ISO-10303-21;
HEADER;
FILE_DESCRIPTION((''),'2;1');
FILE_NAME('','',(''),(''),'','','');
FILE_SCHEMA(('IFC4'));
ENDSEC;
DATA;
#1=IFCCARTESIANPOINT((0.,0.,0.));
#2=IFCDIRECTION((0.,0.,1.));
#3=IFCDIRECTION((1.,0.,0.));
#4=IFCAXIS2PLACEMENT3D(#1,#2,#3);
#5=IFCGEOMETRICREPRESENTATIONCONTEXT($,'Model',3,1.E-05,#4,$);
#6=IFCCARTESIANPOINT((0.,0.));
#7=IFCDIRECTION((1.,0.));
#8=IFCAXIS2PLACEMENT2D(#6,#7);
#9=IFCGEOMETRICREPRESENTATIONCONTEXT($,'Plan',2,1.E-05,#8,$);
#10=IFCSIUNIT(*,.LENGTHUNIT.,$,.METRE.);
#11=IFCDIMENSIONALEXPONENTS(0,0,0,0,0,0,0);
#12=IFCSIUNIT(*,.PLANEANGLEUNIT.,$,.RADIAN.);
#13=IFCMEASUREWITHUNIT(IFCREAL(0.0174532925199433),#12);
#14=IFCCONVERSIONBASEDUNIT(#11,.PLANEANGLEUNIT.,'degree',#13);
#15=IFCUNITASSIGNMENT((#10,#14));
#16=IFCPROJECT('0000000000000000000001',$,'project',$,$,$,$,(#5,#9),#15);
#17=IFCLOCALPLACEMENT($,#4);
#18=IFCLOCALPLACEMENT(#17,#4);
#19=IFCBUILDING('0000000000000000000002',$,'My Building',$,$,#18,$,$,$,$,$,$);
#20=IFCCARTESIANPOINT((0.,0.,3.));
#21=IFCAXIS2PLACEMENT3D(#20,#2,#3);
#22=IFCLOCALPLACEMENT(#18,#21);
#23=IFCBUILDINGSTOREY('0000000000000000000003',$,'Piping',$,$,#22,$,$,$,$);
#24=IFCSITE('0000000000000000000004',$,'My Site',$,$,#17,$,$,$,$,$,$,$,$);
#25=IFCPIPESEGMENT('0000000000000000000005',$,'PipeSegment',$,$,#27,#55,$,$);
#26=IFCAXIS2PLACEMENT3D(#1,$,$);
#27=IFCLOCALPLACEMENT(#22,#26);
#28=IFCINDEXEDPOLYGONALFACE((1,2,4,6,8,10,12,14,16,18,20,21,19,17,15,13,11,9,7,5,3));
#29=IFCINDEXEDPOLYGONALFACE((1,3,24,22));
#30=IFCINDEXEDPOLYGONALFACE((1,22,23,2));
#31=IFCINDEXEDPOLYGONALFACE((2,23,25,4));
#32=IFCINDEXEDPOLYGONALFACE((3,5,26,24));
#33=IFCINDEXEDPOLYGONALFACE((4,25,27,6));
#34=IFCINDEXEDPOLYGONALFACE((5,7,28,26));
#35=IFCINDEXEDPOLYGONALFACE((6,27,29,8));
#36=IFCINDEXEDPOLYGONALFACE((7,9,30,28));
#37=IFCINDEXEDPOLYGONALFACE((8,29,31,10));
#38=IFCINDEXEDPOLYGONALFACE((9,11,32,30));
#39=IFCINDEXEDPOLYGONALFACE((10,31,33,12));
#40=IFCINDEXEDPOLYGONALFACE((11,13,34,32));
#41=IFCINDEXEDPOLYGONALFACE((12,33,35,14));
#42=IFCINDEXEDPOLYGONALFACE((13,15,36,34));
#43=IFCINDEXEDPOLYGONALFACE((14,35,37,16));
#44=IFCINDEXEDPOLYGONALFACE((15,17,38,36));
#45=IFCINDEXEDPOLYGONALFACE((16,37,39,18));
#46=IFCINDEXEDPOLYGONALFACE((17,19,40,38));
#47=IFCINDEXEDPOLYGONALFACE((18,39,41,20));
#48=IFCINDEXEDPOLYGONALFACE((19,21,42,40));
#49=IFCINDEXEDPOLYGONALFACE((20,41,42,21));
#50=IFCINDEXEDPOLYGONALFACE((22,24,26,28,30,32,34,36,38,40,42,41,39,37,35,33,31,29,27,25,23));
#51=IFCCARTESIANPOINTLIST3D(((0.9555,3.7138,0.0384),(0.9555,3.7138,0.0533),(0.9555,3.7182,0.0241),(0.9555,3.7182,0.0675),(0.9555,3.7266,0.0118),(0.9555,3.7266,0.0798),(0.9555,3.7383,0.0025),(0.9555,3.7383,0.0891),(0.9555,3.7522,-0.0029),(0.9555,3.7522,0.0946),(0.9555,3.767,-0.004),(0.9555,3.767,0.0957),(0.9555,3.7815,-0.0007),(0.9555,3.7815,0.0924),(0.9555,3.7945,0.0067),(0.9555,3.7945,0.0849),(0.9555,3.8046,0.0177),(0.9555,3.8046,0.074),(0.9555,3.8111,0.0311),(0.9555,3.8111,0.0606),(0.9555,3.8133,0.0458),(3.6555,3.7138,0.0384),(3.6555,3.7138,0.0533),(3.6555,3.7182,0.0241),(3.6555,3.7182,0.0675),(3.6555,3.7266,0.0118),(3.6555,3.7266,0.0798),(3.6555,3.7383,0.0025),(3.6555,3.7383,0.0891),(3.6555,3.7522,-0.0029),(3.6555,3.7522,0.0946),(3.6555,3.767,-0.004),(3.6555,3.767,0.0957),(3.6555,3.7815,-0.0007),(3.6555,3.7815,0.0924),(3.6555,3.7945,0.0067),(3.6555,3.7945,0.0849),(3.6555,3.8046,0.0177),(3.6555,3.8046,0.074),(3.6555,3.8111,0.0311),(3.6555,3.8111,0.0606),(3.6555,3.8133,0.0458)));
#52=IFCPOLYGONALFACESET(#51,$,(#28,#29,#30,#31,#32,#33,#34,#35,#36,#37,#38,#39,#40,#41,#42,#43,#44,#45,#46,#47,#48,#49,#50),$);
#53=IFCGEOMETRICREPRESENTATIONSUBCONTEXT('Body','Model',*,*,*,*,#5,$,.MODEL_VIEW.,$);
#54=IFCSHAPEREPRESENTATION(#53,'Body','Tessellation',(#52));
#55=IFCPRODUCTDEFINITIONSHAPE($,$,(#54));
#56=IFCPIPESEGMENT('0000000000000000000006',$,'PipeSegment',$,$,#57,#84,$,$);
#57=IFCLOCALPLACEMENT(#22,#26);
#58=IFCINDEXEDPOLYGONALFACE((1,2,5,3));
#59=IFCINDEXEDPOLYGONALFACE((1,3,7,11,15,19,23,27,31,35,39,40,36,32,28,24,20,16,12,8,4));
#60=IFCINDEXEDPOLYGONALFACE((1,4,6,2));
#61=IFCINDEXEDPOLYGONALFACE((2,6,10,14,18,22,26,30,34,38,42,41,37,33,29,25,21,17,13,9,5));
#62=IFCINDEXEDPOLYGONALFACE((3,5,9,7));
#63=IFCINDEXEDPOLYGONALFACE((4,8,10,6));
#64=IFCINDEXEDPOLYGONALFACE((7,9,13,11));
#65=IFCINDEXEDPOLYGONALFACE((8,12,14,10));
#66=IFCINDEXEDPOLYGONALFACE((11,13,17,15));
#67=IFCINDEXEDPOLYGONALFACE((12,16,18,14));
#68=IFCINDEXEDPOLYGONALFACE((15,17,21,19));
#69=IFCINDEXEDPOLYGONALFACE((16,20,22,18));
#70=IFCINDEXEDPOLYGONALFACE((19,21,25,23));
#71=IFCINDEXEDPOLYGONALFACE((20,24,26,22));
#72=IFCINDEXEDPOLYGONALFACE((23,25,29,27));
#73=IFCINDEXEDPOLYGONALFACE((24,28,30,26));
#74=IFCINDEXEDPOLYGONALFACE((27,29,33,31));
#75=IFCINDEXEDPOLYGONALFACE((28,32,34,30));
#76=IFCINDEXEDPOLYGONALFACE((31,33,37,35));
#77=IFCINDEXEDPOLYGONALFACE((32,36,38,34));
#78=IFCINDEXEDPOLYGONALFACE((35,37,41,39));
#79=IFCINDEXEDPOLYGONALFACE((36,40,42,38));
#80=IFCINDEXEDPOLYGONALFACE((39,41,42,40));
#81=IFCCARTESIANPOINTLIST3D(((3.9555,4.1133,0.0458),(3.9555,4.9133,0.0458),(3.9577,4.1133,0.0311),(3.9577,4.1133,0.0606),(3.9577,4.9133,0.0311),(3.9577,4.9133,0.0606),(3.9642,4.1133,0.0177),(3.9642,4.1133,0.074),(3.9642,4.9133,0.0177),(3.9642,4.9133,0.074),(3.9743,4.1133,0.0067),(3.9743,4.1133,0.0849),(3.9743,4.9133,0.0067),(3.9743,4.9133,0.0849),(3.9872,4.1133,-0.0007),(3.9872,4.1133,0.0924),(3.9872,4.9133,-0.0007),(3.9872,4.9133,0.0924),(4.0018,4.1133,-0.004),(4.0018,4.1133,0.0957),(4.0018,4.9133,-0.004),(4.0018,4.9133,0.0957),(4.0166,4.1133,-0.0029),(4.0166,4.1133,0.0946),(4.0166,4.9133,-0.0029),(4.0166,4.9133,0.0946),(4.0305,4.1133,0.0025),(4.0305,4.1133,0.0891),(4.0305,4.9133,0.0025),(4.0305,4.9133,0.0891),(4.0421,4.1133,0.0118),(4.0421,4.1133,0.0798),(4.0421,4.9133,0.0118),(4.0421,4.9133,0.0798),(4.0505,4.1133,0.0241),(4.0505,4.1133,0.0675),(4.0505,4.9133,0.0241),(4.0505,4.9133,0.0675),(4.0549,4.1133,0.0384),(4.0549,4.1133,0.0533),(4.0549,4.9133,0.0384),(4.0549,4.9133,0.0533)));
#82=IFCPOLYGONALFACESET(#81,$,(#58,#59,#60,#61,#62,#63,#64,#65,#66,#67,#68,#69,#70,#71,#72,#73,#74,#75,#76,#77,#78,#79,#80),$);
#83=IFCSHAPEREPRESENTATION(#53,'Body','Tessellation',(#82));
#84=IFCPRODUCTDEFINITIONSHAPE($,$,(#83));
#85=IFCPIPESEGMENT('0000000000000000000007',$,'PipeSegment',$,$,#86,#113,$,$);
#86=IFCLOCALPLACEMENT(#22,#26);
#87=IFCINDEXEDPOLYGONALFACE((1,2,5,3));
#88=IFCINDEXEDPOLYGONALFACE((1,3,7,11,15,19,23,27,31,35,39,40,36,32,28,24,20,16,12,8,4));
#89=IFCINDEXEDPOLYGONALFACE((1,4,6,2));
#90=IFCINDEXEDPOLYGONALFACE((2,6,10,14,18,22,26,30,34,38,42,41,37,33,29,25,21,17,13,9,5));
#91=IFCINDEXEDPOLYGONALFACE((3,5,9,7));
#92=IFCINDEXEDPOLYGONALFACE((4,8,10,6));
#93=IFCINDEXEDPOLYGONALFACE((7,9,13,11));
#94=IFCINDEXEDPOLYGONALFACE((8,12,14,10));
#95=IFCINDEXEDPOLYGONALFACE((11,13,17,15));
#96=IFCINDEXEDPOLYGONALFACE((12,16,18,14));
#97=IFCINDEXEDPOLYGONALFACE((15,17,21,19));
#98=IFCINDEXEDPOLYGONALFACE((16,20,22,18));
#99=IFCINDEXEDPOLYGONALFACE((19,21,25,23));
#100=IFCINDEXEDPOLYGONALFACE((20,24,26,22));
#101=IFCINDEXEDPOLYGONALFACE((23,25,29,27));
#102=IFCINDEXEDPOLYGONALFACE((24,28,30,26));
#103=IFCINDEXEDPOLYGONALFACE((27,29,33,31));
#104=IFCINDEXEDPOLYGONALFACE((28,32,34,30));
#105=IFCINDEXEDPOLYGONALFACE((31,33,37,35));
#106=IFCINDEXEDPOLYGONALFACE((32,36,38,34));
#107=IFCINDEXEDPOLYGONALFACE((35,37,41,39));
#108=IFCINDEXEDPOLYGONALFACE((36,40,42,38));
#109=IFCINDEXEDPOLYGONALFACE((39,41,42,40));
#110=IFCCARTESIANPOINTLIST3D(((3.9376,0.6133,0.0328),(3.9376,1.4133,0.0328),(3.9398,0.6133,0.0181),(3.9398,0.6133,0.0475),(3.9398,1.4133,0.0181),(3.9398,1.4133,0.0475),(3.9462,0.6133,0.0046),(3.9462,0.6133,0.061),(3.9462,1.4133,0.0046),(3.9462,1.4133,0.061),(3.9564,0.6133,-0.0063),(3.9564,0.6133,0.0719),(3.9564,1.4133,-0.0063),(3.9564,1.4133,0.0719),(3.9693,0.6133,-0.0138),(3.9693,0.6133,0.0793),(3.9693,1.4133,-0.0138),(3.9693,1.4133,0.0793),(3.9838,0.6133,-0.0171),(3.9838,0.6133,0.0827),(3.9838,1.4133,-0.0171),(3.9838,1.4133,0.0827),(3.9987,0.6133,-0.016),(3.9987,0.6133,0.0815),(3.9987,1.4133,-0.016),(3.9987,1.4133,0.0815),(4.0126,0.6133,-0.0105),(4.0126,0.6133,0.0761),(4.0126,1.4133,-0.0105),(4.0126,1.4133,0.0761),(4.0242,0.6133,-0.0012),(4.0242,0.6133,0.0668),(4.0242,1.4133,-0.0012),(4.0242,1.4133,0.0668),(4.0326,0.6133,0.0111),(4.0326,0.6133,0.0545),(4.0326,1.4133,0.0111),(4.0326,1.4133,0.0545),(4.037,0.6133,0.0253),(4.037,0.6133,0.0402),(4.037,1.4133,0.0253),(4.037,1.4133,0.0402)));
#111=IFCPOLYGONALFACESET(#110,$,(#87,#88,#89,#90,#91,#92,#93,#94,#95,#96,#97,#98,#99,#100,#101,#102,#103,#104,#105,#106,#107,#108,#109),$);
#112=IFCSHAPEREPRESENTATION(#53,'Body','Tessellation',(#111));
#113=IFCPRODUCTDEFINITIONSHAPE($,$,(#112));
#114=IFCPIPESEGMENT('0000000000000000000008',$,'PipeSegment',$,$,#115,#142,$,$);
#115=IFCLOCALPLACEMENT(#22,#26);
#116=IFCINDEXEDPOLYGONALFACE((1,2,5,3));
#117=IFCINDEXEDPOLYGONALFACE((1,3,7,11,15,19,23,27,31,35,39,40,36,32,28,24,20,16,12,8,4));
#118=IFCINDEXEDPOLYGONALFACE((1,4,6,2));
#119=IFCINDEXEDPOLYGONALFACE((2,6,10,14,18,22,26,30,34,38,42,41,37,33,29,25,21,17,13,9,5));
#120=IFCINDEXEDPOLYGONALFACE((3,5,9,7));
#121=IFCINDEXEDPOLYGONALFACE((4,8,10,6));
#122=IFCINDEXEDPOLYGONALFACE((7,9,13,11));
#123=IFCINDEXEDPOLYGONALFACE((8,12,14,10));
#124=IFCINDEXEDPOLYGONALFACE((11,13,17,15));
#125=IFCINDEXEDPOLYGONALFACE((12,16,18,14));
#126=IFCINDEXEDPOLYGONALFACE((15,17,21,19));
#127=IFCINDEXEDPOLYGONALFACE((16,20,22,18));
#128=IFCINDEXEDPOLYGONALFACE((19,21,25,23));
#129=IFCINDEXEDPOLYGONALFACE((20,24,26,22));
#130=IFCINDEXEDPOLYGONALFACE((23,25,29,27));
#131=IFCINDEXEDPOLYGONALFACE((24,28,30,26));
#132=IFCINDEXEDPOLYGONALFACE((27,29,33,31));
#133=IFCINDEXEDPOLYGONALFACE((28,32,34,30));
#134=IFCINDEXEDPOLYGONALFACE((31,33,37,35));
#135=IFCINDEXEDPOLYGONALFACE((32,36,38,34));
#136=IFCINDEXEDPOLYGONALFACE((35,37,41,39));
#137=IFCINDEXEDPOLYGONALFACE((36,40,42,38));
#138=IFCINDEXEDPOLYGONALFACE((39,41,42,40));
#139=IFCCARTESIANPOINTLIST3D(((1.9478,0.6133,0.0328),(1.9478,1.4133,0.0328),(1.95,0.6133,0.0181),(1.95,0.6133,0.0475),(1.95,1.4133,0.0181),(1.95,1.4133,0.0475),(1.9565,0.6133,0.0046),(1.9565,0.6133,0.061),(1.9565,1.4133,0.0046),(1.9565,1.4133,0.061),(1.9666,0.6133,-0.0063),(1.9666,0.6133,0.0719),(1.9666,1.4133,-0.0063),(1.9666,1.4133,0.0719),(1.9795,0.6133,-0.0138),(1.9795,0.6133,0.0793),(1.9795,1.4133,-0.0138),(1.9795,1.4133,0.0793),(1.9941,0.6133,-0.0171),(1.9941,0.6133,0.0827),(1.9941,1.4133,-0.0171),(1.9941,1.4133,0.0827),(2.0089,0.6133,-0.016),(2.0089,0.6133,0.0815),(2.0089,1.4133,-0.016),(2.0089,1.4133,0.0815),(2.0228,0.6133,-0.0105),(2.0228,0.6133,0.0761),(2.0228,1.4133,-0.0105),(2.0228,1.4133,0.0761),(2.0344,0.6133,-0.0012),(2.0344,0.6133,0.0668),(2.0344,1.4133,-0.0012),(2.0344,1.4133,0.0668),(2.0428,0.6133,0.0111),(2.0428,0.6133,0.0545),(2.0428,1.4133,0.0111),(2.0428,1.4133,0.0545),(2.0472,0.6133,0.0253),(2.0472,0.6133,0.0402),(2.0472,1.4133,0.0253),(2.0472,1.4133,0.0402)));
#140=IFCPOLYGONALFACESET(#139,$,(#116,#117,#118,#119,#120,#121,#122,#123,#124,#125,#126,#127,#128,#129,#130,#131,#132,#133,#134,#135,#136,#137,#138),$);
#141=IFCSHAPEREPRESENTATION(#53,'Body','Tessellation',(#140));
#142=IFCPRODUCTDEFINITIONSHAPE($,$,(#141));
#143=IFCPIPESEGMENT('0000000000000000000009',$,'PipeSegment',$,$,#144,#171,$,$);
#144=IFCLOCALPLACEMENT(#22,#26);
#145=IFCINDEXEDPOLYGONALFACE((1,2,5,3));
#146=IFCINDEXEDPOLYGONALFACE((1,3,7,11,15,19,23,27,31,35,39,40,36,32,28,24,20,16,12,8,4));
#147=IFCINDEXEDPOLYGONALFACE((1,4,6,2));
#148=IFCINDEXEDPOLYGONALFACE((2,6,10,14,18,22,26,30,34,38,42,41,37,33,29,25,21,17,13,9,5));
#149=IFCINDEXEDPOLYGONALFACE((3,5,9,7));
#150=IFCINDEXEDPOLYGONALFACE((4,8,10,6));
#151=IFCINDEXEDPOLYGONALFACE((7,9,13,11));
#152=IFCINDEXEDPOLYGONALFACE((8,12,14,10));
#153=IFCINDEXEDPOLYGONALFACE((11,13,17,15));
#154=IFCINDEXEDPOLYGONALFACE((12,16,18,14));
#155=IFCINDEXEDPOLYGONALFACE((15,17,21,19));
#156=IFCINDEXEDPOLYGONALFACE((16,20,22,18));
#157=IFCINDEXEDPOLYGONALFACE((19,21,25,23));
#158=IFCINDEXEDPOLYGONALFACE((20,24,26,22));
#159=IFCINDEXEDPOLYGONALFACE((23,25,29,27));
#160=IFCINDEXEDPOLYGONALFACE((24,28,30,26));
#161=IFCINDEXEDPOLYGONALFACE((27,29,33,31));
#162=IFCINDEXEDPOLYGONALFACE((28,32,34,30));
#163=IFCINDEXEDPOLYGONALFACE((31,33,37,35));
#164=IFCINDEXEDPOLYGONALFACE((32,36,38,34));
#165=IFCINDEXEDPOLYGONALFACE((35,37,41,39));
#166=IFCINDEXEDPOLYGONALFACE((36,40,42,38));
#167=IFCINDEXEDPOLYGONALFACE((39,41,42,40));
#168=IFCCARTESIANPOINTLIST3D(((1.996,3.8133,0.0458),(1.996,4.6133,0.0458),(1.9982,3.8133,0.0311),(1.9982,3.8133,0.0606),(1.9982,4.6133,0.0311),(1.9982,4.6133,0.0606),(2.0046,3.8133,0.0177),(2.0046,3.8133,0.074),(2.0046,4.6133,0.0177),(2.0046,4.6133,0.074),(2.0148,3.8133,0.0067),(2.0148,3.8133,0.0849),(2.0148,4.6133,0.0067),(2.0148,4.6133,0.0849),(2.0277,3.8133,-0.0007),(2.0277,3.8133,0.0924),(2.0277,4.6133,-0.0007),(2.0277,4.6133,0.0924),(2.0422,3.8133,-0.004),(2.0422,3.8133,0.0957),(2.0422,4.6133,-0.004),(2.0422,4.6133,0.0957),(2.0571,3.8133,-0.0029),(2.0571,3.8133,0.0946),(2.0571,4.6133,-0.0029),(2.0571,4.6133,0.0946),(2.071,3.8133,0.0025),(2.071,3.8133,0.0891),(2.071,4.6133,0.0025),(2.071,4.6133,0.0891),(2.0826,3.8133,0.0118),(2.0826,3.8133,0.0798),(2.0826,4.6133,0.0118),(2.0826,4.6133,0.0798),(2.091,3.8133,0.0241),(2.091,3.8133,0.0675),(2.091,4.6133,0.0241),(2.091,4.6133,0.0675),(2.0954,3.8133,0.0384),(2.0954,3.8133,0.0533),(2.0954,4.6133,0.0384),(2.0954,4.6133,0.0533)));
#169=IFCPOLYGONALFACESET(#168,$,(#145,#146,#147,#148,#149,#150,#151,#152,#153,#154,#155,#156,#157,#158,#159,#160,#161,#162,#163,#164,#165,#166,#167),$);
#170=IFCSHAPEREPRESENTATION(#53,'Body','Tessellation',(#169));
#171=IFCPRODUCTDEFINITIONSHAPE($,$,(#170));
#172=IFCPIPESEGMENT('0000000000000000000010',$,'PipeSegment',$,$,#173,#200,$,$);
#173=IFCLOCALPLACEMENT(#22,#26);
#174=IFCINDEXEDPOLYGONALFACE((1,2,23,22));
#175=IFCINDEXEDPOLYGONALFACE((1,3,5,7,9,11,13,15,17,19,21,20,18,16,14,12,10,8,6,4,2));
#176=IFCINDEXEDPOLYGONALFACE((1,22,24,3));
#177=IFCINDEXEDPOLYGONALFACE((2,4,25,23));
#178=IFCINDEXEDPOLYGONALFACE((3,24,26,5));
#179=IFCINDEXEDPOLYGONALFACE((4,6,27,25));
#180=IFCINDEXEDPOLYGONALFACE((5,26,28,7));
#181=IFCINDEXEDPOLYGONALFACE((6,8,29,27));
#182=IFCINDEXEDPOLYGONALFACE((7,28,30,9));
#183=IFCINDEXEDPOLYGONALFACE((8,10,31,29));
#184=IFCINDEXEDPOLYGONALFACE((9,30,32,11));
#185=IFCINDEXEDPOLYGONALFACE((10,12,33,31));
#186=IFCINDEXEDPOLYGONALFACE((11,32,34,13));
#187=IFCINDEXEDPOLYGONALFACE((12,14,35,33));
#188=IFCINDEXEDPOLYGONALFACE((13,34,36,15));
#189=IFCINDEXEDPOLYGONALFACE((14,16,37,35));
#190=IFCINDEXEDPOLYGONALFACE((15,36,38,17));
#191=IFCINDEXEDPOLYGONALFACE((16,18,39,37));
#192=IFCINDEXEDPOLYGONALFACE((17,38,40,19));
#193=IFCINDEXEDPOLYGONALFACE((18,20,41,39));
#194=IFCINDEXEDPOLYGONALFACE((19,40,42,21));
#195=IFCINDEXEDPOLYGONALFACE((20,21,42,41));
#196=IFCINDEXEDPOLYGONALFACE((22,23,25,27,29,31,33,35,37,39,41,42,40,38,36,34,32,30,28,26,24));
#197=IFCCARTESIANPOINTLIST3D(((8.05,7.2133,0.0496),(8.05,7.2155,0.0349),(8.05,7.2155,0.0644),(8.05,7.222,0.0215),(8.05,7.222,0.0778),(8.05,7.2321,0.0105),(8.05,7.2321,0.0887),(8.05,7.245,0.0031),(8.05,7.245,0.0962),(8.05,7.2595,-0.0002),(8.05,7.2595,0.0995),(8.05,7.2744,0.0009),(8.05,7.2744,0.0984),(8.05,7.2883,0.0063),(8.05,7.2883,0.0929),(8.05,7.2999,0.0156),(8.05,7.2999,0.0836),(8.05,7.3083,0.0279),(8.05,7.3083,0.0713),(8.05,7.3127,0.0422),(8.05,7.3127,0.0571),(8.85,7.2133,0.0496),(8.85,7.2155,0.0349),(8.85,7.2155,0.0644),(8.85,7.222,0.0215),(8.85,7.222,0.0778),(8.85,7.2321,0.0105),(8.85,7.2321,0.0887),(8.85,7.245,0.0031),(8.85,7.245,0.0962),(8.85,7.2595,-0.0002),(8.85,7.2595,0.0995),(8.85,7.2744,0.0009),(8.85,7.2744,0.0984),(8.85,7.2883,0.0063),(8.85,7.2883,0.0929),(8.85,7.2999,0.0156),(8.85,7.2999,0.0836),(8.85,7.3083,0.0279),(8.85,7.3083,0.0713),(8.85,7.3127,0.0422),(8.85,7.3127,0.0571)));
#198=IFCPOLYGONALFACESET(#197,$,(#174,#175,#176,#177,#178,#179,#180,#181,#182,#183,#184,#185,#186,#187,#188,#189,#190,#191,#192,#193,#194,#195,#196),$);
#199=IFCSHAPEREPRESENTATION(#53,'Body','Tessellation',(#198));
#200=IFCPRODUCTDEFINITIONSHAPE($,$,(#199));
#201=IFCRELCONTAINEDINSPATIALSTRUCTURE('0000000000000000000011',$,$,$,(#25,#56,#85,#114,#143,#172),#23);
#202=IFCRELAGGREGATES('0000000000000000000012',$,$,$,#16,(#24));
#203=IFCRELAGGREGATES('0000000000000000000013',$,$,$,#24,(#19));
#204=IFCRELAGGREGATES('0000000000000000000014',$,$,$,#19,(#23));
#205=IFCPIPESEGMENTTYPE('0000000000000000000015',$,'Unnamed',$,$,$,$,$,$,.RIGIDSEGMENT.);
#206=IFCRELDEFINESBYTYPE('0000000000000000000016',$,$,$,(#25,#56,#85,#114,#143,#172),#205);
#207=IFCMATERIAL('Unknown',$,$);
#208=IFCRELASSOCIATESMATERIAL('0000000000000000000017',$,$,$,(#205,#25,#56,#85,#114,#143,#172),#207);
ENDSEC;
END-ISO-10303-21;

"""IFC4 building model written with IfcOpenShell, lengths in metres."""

from ifc_helpers import new_model, entity, si_unit, converted_unit, frame, origin_with_axes, origin_2d_with_axis, place, context, subcontext, project, spatial, circle, extrude, material, material_profile, profile_set, profile_usage, type_object, element, save


model = new_model("IFC4")

# Units and contexts
model_context = context("Model", 3, precision=1e-05, world=origin_with_axes())
plan_context = context("Plan", 2, precision=1e-05, world=origin_2d_with_axis())
body_context = subcontext(model_context, "Body", "Model", "MODEL_VIEW")
ifc_project = project(units=[si_unit("LENGTHUNIT", "METRE"), converted_unit("PLANEANGLEUNIT", "degree", entity("IfcReal", 0.0174532925199433), si_unit("PLANEANGLEUNIT", "RADIAN"), dimensions=[0, 0, 0, 0, 0, 0, 0])], contexts=[model_context, plan_context])

# Site, building, storey
site_placement = place(None, origin_with_axes())
site = spatial("IfcSite", under=ifc_project, at=site_placement, Name="My Site")
building_placement = place(site_placement, origin_with_axes())
building = spatial("IfcBuilding", under=site, at=building_placement, Name="My Building")
storey_placement = place(building_placement, frame((0.0, 0.0, 3.0), z_axis=(0.0, 0.0, 1.0), x_axis=(1.0, 0.0, 0.0)))
storey = spatial("IfcBuildingStorey", under=building, at=storey_placement, Name="Piping")

# Pipe segments
ifc_material = material(Name="Unknown")
ifc_material_profile = material_profile(ifc_material, circle(Radius=0.05))
ifc_profile_set = profile_set([ifc_material_profile])
pipe_segment_type = type_object("IfcPipeSegmentType", Name="Unnamed", PredefinedType="RIGIDSEGMENT", material=ifc_profile_set)
ifc_profile_usage_1 = profile_usage(ifc_profile_set, cardinal=10)
pipe_segment_1_placement = place(storey_placement, frame((0.9555, 3.7633, 0.0458), z_axis=(1.0, 0.0, 0.0), x_axis=(0.0, 1.0, 0.0)))
element("IfcPipeSegment", 1, at=pipe_segment_1_placement, inside=storey, type_object=pipe_segment_type, material=ifc_profile_usage_1, Name="PipeSegment", context=body_context, shape_type="SweptSolid", body=[
    extrude(circle(Radius=0.05), origin_with_axes(), (0.0, 0.0, 1.0), 2.7),
])
ifc_profile_usage_2 = profile_usage(ifc_profile_set, cardinal=8)
pipe_segment_2_placement = place(storey_placement, frame((4.0055, 4.1133, 0.0958), z_axis=(0.0, 1.0, 0.0), x_axis=(-1.0, 0.0, 0.0)))
element("IfcPipeSegment", 2, at=pipe_segment_2_placement, inside=storey, type_object=pipe_segment_type, material=ifc_profile_usage_2, Name="PipeSegment", context=body_context, shape_type="SweptSolid", body=[
    extrude(circle(Radius=0.05), frame((0.0, -0.05, 0.0), z_axis=(0.0, 0.0, 1.0), x_axis=(1.0, 0.0, 0.0)), (0.0, 0.0, 1.0), 0.8),
])
ifc_profile_usage_3 = profile_usage(ifc_profile_set, cardinal=8)
pipe_segment_3_placement = place(storey_placement, frame((3.9876, 0.6133, 0.0828), z_axis=(0.0, 1.0, 0.0), x_axis=(-1.0, 0.0, 0.0)))
element("IfcPipeSegment", 3, at=pipe_segment_3_placement, inside=storey, type_object=pipe_segment_type, material=ifc_profile_usage_3, Name="PipeSegment", context=body_context, shape_type="SweptSolid", body=[
    extrude(circle(Radius=0.05), frame((0.0, -0.05, 0.0), z_axis=(0.0, 0.0, 1.0), x_axis=(1.0, 0.0, 0.0)), (0.0, 0.0, 1.0), 0.8),
])
ifc_profile_usage_4 = profile_usage(ifc_profile_set, cardinal=8)
pipe_segment_4_placement = place(storey_placement, frame((1.9978, 0.6133, 0.0828), z_axis=(0.0, 1.0, 0.0), x_axis=(-1.0, 0.0, 0.0)))
element("IfcPipeSegment", 4, at=pipe_segment_4_placement, inside=storey, type_object=pipe_segment_type, material=ifc_profile_usage_4, Name="PipeSegment", context=body_context, shape_type="SweptSolid", body=[
    extrude(circle(Radius=0.05), frame((0.0, -0.05, 0.0), z_axis=(0.0, 0.0, 1.0), x_axis=(1.0, 0.0, 0.0)), (0.0, 0.0, 1.0), 0.8),
])
ifc_profile_usage_5 = profile_usage(ifc_profile_set, cardinal=8)
pipe_segment_5_placement = place(storey_placement, frame((2.046, 3.8133, 0.0958), z_axis=(0.0, 1.0, 0.0), x_axis=(-1.0, 0.0, 0.0)))
element("IfcPipeSegment", 5, at=pipe_segment_5_placement, inside=storey, type_object=pipe_segment_type, material=ifc_profile_usage_5, Name="PipeSegment", context=body_context, shape_type="SweptSolid", body=[
    extrude(circle(Radius=0.05), frame((0.0, -0.05, 0.0), z_axis=(0.0, 0.0, 1.0), x_axis=(1.0, 0.0, 0.0)), (0.0, 0.0, 1.0), 0.8),
])
ifc_profile_usage_6 = profile_usage(ifc_profile_set, cardinal=8)
pipe_segment_6_placement = place(storey_placement, frame((8.85, 7.2633, 0.0996), z_axis=(-1.0, 0.0, 0.0), x_axis=(0.0, -1.0, 0.0)))
element("IfcPipeSegment", 6, at=pipe_segment_6_placement, inside=storey, type_object=pipe_segment_type, material=ifc_profile_usage_6, Name="PipeSegment", context=body_context, shape_type="SweptSolid", body=[
    extrude(circle(Radius=0.05), frame((0.0, -0.05, 0.0), z_axis=(0.0, 0.0, 1.0), x_axis=(1.0, 0.0, 0.0)), (0.0, 0.0, 1.0), 0.8),
])

save(model, "model.ifc")
